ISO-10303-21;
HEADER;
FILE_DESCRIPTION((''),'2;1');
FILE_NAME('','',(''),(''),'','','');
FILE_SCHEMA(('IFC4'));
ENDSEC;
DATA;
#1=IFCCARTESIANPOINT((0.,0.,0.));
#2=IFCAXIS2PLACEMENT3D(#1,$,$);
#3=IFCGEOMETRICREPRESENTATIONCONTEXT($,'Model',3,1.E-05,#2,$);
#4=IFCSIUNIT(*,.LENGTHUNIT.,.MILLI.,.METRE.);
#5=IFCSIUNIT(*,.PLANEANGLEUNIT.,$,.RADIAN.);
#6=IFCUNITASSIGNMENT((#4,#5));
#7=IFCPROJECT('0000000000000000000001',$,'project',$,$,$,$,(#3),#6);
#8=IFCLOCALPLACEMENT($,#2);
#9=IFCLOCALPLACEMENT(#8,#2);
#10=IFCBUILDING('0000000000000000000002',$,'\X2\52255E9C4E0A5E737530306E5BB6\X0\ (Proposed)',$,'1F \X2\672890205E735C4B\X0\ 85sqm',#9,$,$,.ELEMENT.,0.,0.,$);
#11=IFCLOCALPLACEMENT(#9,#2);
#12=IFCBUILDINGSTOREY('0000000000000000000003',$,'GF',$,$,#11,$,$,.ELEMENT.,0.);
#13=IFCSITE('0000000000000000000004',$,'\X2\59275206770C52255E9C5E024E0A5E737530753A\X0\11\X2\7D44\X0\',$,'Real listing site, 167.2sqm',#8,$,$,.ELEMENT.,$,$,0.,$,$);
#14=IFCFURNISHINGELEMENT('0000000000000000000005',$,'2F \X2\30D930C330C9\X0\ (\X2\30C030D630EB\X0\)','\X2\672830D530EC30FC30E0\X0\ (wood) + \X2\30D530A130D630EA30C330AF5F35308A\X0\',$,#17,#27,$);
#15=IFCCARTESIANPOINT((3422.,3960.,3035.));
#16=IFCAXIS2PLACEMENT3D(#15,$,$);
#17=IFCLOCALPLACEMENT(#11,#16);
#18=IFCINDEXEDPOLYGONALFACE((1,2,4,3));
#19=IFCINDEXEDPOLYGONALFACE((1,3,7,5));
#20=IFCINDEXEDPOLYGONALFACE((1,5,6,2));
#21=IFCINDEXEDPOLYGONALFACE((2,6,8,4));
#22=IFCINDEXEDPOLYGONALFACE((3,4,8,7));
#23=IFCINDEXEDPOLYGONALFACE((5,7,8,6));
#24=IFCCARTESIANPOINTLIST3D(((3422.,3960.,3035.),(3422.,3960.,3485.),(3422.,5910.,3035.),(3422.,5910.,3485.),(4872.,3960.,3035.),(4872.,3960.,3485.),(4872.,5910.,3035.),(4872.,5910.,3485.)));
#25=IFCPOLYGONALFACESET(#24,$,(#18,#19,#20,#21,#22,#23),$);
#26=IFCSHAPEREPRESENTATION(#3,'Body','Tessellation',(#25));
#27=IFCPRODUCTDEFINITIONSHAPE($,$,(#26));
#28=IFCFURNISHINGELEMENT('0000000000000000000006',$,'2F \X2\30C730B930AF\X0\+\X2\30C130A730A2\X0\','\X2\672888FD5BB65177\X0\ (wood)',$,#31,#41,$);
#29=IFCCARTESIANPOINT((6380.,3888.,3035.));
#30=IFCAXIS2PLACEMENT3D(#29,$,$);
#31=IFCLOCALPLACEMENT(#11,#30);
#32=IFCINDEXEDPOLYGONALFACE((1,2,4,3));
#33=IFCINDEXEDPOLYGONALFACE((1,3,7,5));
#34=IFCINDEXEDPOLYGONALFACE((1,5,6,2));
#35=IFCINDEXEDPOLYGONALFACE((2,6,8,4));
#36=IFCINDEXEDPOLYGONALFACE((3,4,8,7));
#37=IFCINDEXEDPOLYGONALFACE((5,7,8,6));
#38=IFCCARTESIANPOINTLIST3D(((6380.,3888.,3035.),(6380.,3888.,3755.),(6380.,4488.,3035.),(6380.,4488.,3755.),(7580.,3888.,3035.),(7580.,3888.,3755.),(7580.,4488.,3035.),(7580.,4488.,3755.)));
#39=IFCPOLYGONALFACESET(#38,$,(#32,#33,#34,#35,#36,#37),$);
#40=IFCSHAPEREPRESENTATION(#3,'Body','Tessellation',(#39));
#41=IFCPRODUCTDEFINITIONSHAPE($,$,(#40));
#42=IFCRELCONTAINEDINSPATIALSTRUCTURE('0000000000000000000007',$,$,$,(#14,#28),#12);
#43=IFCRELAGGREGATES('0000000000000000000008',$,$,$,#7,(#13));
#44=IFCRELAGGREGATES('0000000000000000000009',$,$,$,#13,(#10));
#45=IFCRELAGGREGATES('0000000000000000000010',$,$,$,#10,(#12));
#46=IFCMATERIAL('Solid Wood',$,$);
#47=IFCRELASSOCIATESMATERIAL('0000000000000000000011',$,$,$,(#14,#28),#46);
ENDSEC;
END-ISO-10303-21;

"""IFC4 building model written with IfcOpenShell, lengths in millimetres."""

from ifc_helpers import new_model, si_unit, frame, frame_2d, origin, place, context, project, spatial, rectangle, extrude, material, element, save


model = new_model("IFC4")

# Units and contexts
model_context = context("Model", 3, precision=1e-05, world=origin())
ifc_project = project(units=[si_unit("LENGTHUNIT", "METRE", prefix="MILLI"), si_unit("PLANEANGLEUNIT", "RADIAN")], contexts=[model_context])

# Site, building, storey
site_placement = place(None, origin())
site = spatial("IfcSite", under=ifc_project, at=site_placement, Name="大分県別府市上平田町11組", ObjectType="Real listing site, 167.2sqm", CompositionType="ELEMENT", RefElevation=0.0)
building_placement = place(site_placement, origin())
building = spatial("IfcBuilding", under=site, at=building_placement, Name="別府上平田の家 (Proposed)", ObjectType="1F 木造平屋 85sqm", CompositionType="ELEMENT", ElevationOfRefHeight=0.0, ElevationOfTerrain=0.0)
storey_placement = place(building_placement, origin())
storey = spatial("IfcBuildingStorey", under=building, at=storey_placement, Name="GF", CompositionType="ELEMENT", Elevation=0.0)

# Shared definitions
ifc_material_1 = material(Name="Solid Wood")

# Furnishing elements
furnishing_1_placement = place(storey_placement, frame((3422.0, 3960.0, 3035.0)))
element("IfcFurnishingElement", 1, at=furnishing_1_placement, inside=storey, material=ifc_material_1, Name="2F ベッド (ダブル)", Description="木フレーム (wood) + ファブリック張り", context=model_context, shape_type="SweptSolid", body=[
    extrude(rectangle(XDim=1450.0, YDim=1950.0, at=frame_2d((725.0, 975.0))), frame((3422.0, 3960.0, 3035.0)), (0.0, 0.0, 1.0), 450.0),
])
furnishing_2_placement = place(storey_placement, frame((6380.0, 3888.0, 3035.0)))
element("IfcFurnishingElement", 2, at=furnishing_2_placement, inside=storey, material=ifc_material_1, Name="2F デスク+チェア", Description="木製家具 (wood)", context=model_context, shape_type="SweptSolid", body=[
    extrude(rectangle(XDim=1200.0, YDim=600.0, at=frame_2d((600.0, 300.0))), frame((6380.0, 3888.0, 3035.0)), (0.0, 0.0, 1.0), 720.0),
])

save(model, "model.ifc")
